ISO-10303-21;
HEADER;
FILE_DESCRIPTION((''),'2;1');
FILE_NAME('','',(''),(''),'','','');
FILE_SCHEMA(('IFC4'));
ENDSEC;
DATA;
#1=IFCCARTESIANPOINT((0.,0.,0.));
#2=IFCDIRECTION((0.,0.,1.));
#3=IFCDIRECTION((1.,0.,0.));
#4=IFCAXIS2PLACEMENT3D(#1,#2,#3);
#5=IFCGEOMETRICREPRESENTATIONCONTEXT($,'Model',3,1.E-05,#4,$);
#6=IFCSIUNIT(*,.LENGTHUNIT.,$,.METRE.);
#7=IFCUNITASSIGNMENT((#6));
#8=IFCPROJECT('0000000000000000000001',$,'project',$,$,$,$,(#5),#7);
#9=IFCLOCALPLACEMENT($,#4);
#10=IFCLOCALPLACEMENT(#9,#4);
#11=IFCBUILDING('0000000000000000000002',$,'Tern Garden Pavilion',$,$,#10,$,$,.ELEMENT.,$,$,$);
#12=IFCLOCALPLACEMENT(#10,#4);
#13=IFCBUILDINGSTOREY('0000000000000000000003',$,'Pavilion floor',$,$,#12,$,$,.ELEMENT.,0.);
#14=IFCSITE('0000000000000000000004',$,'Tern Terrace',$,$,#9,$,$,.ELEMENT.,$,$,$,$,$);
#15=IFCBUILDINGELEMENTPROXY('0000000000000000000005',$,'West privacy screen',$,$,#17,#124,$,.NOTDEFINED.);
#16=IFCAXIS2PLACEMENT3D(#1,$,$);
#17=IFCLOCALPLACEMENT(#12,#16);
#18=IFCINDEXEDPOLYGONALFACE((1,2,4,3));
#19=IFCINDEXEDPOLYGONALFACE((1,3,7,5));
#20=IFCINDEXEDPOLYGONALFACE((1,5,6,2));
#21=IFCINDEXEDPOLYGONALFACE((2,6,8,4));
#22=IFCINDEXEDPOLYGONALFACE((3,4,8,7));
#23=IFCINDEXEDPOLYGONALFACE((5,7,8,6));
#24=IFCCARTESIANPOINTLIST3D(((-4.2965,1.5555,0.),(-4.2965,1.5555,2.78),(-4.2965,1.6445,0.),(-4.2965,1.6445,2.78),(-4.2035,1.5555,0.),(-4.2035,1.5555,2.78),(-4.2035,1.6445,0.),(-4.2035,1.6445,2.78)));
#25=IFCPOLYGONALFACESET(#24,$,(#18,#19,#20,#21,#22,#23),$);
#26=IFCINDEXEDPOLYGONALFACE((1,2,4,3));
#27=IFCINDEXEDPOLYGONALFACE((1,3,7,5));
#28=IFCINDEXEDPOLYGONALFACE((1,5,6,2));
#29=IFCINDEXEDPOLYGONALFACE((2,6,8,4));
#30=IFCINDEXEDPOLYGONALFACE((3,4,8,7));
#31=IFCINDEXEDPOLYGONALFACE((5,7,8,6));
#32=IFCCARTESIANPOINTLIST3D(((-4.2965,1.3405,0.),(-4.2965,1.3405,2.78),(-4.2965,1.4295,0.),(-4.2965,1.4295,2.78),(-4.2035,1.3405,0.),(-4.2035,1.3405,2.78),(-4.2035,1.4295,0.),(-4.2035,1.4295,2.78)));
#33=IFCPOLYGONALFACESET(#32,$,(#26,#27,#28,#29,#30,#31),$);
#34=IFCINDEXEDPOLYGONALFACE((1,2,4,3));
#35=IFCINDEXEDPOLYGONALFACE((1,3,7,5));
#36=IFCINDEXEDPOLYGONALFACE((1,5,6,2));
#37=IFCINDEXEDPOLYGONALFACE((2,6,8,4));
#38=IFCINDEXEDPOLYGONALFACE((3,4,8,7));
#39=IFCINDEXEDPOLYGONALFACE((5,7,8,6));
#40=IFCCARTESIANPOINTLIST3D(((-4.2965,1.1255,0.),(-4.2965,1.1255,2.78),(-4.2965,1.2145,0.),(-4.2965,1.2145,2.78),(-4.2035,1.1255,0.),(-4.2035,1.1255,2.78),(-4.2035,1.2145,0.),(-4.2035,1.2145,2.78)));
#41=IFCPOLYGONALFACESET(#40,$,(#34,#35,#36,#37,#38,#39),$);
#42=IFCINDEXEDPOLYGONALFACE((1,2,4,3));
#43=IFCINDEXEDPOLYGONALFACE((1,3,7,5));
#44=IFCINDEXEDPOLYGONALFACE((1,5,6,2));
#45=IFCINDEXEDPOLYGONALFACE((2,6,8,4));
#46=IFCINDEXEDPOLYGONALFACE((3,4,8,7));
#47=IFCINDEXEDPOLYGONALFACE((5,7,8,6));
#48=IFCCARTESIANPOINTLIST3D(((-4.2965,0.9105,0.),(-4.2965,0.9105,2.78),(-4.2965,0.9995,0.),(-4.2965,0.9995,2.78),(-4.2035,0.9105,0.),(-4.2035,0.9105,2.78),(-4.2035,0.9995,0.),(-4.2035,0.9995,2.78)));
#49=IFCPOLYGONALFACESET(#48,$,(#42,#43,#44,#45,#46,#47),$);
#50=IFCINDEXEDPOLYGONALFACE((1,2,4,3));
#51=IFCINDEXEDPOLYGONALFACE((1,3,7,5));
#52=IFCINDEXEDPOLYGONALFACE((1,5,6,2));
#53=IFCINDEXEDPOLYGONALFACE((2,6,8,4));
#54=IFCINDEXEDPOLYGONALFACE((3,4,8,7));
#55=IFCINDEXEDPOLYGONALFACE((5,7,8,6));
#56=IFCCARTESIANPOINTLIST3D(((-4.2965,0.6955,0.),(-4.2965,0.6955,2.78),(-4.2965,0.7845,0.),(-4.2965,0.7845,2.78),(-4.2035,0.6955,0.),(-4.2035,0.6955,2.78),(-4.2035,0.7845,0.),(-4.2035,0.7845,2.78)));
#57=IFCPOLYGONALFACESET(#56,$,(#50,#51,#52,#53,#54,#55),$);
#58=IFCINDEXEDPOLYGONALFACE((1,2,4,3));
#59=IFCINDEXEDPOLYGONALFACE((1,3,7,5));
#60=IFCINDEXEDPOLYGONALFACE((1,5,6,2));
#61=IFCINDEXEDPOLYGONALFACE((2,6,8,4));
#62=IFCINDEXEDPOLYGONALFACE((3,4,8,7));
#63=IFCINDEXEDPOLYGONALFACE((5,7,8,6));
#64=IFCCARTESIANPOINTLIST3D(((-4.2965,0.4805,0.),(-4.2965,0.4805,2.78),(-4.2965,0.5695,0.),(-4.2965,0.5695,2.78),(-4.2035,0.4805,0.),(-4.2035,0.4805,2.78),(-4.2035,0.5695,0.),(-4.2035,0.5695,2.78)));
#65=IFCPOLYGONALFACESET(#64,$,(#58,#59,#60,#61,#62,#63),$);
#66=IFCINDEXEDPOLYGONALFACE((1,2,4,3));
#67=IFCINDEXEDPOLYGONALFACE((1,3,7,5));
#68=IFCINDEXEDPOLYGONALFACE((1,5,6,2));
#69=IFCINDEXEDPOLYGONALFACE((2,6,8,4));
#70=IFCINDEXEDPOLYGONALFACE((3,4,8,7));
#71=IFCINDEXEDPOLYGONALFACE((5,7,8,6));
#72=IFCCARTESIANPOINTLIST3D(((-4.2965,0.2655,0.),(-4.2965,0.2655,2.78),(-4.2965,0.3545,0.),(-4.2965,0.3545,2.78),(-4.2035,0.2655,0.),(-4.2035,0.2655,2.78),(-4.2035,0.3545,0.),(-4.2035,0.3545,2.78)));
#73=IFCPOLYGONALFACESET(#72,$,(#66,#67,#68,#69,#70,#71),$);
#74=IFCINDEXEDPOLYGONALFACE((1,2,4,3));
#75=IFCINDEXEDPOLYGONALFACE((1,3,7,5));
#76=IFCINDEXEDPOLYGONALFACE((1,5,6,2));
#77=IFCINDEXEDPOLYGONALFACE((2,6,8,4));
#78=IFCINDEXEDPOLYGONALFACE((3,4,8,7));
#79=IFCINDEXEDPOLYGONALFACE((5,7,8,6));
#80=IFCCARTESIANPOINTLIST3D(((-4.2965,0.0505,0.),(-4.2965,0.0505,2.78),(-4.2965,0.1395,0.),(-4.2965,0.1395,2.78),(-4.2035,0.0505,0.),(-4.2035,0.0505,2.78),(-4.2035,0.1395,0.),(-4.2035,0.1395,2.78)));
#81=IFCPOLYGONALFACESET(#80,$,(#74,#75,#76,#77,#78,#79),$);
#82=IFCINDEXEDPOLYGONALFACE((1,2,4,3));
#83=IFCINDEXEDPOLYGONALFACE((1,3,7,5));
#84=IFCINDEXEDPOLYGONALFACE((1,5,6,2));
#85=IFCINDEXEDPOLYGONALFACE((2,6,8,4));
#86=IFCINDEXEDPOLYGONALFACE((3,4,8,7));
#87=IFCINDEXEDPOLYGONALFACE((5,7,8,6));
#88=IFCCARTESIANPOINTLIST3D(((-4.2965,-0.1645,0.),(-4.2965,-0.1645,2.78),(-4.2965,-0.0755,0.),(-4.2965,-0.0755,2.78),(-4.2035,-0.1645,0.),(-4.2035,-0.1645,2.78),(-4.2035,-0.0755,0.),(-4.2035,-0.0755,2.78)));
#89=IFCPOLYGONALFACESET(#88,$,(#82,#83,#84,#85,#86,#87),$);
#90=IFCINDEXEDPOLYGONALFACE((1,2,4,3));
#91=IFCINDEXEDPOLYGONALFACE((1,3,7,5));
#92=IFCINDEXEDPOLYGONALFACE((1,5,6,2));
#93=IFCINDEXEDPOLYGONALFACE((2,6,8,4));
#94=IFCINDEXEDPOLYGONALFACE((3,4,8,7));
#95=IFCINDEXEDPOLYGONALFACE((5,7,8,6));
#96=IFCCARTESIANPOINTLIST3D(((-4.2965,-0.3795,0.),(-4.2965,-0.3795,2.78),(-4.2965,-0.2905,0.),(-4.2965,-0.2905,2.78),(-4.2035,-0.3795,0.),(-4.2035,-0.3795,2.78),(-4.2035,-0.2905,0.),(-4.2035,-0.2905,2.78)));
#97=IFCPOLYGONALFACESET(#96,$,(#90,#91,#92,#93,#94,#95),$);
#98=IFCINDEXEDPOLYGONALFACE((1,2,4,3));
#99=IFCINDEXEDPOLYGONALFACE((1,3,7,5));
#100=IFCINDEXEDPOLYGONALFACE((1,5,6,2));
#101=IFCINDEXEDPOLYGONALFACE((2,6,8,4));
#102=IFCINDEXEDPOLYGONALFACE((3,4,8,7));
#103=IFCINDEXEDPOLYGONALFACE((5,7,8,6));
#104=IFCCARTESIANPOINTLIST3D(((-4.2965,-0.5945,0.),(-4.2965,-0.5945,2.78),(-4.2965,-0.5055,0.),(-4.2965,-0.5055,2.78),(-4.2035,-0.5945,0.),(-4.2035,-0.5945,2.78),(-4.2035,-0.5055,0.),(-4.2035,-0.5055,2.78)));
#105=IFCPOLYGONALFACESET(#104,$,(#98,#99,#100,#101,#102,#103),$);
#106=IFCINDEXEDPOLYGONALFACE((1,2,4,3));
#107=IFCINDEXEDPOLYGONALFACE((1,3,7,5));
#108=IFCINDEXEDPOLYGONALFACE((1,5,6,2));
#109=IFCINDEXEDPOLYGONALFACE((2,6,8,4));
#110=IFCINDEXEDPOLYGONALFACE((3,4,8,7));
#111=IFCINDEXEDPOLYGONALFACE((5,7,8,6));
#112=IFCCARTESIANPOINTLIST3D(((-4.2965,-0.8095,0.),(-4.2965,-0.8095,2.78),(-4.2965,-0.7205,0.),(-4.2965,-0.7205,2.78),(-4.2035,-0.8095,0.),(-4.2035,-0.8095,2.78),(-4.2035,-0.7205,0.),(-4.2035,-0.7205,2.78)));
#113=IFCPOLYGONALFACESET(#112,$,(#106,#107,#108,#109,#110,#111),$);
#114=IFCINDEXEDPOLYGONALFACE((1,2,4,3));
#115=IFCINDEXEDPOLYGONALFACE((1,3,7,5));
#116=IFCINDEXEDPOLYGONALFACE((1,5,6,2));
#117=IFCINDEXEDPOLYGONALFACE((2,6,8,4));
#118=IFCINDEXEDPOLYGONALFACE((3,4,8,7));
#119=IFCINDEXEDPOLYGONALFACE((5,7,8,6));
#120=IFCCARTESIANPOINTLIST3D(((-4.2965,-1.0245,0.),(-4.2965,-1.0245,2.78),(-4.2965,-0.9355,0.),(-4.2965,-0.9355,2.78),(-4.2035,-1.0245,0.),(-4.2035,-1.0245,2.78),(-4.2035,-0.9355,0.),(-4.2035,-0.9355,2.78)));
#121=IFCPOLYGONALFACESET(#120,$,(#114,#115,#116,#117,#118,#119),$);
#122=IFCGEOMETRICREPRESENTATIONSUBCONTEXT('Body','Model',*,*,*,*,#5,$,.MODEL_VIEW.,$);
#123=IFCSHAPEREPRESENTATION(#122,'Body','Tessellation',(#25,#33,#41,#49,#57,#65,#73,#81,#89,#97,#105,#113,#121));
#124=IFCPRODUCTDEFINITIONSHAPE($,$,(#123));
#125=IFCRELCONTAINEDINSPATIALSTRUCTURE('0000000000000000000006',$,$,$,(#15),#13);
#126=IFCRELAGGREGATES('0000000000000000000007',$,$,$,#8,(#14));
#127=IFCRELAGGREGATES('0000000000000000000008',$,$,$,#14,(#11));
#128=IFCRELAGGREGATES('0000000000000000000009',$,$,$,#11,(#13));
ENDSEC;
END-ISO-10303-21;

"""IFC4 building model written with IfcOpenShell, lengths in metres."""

from ifc_helpers import new_model, si_unit, frame, origin_with_axes, origin_2d, place, context, subcontext, project, spatial, rectangle, extrude, element, save


model = new_model("IFC4")

# Units and contexts
model_context = context("Model", 3, precision=1e-05, world=origin_with_axes())
body_context = subcontext(model_context, "Body", "Model", "MODEL_VIEW")
ifc_project = project(units=[si_unit("LENGTHUNIT", "METRE")], contexts=[model_context])

# Site, building, storey
site_placement = place(None, origin_with_axes())
site = spatial("IfcSite", under=ifc_project, at=site_placement, Name="Tern Terrace", CompositionType="ELEMENT")
building_placement = place(site_placement, origin_with_axes())
building = spatial("IfcBuilding", under=site, at=building_placement, Name="Tern Garden Pavilion", CompositionType="ELEMENT")
storey_placement = place(building_placement, origin_with_axes())
storey = spatial("IfcBuildingStorey", under=building, at=storey_placement, Name="Pavilion floor", CompositionType="ELEMENT", Elevation=0.0)

# Building element proxy
proxy_1_placement = place(storey_placement, origin_with_axes())
element("IfcBuildingElementProxy", 1, at=proxy_1_placement, inside=storey, Name="West privacy screen", PredefinedType="NOTDEFINED", context=body_context, shape_type="SweptSolid", body=[
    extrude(rectangle(XDim=0.093, YDim=0.089, at=origin_2d()), frame((-4.25, 1.6, 0.0), z_axis=(0.0, 0.0, 1.0), x_axis=(1.0, 0.0, 0.0)), (0.0, 0.0, 1.0), 2.78),
    extrude(rectangle(XDim=0.093, YDim=0.089, at=origin_2d()), frame((-4.25, 1.385, 0.0), z_axis=(0.0, 0.0, 1.0), x_axis=(1.0, 0.0, 0.0)), (0.0, 0.0, 1.0), 2.78),
    extrude(rectangle(XDim=0.093, YDim=0.089, at=origin_2d()), frame((-4.25, 1.17, 0.0), z_axis=(0.0, 0.0, 1.0), x_axis=(1.0, 0.0, 0.0)), (0.0, 0.0, 1.0), 2.78),
    extrude(rectangle(XDim=0.093, YDim=0.089, at=origin_2d()), frame((-4.25, 0.955, 0.0), z_axis=(0.0, 0.0, 1.0), x_axis=(1.0, 0.0, 0.0)), (0.0, 0.0, 1.0), 2.78),
    extrude(rectangle(XDim=0.093, YDim=0.089, at=origin_2d()), frame((-4.25, 0.74, 0.0), z_axis=(0.0, 0.0, 1.0), x_axis=(1.0, 0.0, 0.0)), (0.0, 0.0, 1.0), 2.78),
    extrude(rectangle(XDim=0.093, YDim=0.089, at=origin_2d()), frame((-4.25, 0.525, 0.0), z_axis=(0.0, 0.0, 1.0), x_axis=(1.0, 0.0, 0.0)), (0.0, 0.0, 1.0), 2.78),
    extrude(rectangle(XDim=0.093, YDim=0.089, at=origin_2d()), frame((-4.25, 0.31, 0.0), z_axis=(0.0, 0.0, 1.0), x_axis=(1.0, 0.0, 0.0)), (0.0, 0.0, 1.0), 2.78),
    extrude(rectangle(XDim=0.093, YDim=0.089, at=origin_2d()), frame((-4.25, 0.095, 0.0), z_axis=(0.0, 0.0, 1.0), x_axis=(1.0, 0.0, 0.0)), (0.0, 0.0, 1.0), 2.78),
    extrude(rectangle(XDim=0.093, YDim=0.089, at=origin_2d()), frame((-4.25, -0.12, 0.0), z_axis=(0.0, 0.0, 1.0), x_axis=(1.0, 0.0, 0.0)), (0.0, 0.0, 1.0), 2.78),
    extrude(rectangle(XDim=0.093, YDim=0.089, at=origin_2d()), frame((-4.25, -0.335, 0.0), z_axis=(0.0, 0.0, 1.0), x_axis=(1.0, 0.0, 0.0)), (0.0, 0.0, 1.0), 2.78),
    extrude(rectangle(XDim=0.093, YDim=0.089, at=origin_2d()), frame((-4.25, -0.55, 0.0), z_axis=(0.0, 0.0, 1.0), x_axis=(1.0, 0.0, 0.0)), (0.0, 0.0, 1.0), 2.78),
    extrude(rectangle(XDim=0.093, YDim=0.089, at=origin_2d()), frame((-4.25, -0.765, 0.0), z_axis=(0.0, 0.0, 1.0), x_axis=(1.0, 0.0, 0.0)), (0.0, 0.0, 1.0), 2.78),
    extrude(rectangle(XDim=0.093, YDim=0.089, at=origin_2d()), frame((-4.25, -0.98, 0.0), z_axis=(0.0, 0.0, 1.0), x_axis=(1.0, 0.0, 0.0)), (0.0, 0.0, 1.0), 2.78),
])

save(model, "model.ifc")
